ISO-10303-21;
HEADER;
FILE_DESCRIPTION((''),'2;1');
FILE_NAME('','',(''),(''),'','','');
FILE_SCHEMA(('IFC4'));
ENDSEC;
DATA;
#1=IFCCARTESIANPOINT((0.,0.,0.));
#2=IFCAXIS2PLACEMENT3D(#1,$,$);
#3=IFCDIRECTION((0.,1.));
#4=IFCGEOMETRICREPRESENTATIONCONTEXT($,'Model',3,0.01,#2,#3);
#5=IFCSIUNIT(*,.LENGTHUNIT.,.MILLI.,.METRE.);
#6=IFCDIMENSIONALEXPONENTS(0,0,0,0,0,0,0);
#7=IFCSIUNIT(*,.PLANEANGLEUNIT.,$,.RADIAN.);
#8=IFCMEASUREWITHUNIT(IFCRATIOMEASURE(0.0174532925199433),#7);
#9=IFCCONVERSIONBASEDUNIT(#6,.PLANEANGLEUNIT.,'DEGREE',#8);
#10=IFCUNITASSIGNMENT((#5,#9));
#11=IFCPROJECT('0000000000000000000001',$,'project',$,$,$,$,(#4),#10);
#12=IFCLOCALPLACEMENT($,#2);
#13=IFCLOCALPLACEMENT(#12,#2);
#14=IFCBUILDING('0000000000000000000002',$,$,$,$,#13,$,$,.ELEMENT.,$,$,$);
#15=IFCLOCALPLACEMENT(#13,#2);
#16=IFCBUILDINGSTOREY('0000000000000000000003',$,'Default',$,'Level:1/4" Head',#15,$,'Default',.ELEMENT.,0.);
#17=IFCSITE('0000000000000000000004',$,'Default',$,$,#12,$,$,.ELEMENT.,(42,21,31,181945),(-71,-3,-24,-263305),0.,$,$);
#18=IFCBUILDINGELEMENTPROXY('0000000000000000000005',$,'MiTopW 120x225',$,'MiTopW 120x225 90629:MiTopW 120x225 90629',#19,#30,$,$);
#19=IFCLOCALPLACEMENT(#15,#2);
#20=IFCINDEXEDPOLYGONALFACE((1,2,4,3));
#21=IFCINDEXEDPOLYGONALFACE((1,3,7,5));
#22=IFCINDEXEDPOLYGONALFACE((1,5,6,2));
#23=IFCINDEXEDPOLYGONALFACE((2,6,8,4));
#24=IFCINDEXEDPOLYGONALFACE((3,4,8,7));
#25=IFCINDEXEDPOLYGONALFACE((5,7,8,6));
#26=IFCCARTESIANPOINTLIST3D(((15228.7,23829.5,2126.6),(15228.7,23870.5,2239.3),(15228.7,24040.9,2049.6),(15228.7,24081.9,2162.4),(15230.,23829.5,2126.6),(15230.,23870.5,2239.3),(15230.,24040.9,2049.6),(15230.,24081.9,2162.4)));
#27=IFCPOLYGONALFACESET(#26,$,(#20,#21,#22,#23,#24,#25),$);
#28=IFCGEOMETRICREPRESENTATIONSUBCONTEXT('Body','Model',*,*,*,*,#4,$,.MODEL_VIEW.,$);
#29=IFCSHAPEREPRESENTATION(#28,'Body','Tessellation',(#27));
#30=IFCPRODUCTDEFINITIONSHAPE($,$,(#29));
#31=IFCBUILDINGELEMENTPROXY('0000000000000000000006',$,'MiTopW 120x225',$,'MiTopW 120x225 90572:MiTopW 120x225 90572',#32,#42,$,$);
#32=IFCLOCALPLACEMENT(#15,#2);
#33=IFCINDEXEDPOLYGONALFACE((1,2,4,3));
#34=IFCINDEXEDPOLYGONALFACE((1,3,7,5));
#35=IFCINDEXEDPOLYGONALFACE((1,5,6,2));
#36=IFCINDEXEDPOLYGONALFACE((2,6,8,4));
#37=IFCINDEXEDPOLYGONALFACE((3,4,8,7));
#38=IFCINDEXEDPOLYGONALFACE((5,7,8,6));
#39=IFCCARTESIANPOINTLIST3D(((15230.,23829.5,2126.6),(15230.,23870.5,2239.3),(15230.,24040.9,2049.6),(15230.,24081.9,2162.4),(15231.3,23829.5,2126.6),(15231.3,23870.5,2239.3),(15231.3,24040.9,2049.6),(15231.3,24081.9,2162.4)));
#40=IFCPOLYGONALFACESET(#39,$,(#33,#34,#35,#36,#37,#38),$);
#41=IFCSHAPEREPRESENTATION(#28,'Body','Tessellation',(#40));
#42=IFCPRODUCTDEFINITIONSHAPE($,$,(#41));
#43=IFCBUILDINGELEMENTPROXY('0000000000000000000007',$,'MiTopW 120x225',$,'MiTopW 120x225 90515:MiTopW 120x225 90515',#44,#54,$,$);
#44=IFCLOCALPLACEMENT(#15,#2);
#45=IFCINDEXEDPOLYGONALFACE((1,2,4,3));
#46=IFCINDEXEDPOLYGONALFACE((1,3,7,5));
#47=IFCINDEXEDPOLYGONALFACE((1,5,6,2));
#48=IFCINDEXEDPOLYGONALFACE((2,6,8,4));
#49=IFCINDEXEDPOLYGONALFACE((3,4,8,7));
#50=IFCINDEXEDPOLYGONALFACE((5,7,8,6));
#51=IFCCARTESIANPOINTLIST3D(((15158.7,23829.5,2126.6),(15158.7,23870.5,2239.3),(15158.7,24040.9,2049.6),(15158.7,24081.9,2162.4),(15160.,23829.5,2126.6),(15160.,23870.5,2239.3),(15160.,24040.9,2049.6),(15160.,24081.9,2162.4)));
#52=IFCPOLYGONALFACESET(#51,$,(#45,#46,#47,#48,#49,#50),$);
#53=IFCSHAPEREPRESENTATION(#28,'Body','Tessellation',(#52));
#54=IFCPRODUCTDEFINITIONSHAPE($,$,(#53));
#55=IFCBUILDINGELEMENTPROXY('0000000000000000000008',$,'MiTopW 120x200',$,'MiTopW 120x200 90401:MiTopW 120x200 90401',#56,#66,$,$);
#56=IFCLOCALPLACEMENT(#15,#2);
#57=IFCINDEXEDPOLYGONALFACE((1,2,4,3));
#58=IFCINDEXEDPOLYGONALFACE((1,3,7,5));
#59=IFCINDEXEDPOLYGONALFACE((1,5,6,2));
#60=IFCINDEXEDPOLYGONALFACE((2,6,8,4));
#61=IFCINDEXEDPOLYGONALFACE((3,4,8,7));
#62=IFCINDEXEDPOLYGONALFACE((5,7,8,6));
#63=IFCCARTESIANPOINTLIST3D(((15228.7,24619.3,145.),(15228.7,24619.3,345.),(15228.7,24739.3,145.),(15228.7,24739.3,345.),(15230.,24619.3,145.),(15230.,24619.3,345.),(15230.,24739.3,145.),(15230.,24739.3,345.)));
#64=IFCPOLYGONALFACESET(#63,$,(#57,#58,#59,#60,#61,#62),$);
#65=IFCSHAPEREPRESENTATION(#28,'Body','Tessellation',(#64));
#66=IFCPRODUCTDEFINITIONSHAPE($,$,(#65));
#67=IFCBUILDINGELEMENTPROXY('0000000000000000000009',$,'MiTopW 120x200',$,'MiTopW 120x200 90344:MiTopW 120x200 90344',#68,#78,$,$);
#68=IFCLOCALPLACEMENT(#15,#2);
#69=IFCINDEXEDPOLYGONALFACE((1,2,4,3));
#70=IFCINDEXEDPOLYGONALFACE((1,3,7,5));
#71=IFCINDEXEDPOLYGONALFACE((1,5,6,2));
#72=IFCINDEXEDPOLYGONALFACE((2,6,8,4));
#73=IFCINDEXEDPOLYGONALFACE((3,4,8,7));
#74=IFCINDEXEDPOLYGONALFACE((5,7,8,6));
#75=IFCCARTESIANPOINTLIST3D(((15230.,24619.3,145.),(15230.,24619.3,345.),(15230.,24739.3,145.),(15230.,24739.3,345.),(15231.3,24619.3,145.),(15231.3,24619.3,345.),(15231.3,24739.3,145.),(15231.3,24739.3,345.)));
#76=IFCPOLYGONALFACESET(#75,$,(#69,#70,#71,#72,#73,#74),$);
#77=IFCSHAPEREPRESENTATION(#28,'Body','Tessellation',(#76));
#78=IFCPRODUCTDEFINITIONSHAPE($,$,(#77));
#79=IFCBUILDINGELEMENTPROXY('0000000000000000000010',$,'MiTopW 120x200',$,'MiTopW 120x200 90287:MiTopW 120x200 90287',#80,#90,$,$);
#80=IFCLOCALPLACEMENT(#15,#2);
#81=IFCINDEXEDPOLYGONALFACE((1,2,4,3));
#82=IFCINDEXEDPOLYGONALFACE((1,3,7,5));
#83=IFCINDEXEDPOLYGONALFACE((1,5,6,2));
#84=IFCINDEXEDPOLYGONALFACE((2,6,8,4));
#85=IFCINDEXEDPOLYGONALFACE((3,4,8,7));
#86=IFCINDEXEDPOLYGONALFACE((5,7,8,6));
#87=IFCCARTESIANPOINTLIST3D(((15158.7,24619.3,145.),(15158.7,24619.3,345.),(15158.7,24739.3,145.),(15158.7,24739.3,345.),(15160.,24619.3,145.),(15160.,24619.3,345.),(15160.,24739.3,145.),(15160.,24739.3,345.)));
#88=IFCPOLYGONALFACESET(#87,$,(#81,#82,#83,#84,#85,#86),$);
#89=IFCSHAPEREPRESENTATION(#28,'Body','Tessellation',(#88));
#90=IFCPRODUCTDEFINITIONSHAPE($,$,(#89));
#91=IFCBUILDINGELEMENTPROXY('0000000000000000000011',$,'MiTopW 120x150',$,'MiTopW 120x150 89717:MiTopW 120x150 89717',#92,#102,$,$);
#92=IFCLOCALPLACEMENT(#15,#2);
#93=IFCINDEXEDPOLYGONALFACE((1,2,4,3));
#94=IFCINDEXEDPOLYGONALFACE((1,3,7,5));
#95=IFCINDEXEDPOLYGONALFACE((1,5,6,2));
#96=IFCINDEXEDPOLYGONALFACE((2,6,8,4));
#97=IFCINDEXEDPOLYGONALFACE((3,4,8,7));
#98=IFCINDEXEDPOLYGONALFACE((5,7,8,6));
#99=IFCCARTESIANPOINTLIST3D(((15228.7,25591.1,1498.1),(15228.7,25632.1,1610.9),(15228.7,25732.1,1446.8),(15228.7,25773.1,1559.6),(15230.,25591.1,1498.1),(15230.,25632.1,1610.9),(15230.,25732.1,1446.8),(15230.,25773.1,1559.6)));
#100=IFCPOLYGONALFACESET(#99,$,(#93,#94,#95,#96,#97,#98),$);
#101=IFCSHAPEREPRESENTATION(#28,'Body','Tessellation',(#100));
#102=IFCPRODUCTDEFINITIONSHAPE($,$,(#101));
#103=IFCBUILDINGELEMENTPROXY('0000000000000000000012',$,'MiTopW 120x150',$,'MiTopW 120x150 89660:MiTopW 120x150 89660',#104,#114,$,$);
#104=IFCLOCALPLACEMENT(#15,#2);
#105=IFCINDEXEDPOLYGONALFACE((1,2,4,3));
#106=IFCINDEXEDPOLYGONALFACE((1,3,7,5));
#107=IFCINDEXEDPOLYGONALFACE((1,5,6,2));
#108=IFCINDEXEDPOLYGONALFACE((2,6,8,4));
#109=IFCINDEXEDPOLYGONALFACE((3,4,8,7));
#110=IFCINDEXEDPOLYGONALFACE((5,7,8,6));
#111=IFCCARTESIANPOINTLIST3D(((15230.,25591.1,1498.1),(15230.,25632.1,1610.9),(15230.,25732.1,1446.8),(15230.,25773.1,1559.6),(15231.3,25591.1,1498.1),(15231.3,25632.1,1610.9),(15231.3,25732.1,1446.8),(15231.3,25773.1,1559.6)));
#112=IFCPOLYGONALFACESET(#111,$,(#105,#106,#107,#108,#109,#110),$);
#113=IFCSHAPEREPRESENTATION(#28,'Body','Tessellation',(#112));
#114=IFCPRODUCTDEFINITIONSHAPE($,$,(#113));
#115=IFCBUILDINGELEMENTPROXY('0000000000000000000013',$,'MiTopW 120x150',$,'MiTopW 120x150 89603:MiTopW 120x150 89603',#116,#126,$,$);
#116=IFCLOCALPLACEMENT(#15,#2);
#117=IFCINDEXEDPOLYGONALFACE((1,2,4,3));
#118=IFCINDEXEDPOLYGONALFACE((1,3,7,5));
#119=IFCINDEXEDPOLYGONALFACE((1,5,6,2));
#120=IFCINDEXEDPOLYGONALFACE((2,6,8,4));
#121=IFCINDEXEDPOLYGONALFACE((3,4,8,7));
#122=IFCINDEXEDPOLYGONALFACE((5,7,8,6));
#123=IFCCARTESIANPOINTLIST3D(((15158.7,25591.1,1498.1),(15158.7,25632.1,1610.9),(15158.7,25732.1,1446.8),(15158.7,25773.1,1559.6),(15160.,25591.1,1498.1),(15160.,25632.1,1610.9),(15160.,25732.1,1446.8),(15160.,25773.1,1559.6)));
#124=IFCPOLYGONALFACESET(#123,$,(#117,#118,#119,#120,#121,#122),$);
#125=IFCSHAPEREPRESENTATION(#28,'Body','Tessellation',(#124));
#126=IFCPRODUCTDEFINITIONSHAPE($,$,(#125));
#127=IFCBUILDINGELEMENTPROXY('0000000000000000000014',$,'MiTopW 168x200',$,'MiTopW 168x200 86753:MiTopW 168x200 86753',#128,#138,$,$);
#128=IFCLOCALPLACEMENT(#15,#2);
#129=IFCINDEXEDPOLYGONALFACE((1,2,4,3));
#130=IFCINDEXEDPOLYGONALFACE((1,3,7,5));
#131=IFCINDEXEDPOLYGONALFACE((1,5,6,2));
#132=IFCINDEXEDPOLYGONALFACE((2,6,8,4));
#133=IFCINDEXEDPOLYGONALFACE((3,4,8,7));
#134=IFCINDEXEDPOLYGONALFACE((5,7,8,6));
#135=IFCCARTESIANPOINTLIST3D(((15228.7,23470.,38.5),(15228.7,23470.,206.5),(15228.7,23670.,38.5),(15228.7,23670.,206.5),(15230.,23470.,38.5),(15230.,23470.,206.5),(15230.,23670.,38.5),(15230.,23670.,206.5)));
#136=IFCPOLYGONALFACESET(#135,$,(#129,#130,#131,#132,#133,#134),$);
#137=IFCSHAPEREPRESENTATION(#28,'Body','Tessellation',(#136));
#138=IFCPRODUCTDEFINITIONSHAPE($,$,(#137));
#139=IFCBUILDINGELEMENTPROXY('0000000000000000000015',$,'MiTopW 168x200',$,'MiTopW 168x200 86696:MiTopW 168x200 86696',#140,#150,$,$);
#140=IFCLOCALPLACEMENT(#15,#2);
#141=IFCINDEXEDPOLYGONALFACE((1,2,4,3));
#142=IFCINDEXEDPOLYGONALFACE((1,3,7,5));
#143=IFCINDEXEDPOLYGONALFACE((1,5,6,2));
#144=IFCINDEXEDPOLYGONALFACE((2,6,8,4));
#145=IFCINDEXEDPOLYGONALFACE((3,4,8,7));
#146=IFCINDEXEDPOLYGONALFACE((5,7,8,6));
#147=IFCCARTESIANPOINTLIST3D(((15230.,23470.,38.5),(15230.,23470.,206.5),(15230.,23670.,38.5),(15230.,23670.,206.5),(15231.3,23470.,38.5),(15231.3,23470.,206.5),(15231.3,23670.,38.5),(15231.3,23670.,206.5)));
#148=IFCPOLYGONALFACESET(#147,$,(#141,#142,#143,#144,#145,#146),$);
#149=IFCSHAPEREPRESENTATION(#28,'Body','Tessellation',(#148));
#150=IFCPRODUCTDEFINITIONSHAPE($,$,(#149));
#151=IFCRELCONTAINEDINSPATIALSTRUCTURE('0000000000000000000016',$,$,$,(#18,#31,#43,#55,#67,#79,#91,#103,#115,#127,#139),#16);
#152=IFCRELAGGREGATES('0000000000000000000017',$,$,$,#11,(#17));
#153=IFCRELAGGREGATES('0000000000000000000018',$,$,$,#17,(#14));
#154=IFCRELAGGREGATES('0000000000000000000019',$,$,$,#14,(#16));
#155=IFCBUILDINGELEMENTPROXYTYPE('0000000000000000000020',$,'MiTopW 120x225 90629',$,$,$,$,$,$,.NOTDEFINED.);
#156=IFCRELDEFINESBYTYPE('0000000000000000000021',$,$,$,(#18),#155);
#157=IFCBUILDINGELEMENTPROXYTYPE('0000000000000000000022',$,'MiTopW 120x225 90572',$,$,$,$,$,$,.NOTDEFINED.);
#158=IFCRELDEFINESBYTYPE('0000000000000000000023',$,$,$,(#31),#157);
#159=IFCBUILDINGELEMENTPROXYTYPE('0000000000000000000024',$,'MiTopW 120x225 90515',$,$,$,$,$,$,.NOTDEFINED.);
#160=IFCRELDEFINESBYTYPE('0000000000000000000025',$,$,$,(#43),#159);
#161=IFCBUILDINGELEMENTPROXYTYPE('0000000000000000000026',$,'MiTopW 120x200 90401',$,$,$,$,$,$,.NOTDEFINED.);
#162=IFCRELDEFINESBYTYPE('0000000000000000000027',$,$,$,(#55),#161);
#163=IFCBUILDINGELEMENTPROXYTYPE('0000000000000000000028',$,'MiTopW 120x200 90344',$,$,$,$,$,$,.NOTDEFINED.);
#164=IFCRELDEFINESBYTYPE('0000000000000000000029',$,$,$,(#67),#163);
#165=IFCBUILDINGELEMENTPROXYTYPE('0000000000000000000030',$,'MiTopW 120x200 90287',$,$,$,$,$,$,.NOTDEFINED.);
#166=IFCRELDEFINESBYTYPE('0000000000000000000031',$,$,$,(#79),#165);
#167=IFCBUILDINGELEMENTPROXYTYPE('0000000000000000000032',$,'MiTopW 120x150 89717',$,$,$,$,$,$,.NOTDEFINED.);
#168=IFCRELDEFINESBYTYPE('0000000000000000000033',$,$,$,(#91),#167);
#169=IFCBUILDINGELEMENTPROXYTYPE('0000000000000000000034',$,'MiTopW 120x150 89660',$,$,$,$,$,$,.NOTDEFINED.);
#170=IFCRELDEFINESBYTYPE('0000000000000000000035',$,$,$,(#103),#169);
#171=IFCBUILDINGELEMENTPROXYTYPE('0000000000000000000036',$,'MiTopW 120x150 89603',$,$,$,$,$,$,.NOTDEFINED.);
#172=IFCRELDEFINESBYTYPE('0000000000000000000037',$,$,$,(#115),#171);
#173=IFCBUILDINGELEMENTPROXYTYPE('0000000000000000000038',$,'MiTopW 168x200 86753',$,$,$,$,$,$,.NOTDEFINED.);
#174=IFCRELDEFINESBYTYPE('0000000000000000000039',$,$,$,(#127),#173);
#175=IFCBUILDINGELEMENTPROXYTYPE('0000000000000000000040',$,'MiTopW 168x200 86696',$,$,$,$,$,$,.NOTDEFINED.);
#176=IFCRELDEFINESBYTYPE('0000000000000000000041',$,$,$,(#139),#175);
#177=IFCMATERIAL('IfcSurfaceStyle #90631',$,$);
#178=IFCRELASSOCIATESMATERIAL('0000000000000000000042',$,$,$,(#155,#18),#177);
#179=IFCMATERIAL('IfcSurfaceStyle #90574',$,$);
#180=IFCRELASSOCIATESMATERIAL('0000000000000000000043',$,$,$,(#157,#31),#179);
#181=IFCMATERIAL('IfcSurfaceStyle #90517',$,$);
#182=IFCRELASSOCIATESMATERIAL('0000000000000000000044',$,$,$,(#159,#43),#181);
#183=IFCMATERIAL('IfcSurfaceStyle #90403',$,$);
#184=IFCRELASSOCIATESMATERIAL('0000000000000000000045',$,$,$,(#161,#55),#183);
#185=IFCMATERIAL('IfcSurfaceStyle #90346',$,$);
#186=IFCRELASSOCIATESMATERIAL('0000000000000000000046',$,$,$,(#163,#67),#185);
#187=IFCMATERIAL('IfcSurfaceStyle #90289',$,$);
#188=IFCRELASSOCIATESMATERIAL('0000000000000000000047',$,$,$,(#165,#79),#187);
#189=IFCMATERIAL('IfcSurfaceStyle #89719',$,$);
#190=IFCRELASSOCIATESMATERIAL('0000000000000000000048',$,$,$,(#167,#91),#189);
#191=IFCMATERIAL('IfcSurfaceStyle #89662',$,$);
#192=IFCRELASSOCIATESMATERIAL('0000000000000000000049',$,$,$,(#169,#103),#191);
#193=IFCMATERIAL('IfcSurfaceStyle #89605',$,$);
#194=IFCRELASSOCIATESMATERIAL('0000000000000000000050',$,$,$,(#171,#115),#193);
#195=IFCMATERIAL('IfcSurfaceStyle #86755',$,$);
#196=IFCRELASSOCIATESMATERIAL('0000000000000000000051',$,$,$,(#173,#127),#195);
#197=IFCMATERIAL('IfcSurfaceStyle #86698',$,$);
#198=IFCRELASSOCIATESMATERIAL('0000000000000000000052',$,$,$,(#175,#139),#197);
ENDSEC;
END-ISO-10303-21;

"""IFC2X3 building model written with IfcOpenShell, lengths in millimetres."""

from ifc_helpers import new_model, entity, si_unit, converted_unit, direction, frame, origin, origin_2d_with_axis, place, context, subcontext, project, spatial, polyline, rectangle, outline, extrude, source, transform, mapped, material, type_object, type_shapes, element, save


model = new_model("IFC2X3")

# Units and contexts
model_context = context("Model", 3, precision=0.01, world=origin(), true_north=direction((0.0, 1.0)))
body_context = subcontext(model_context, "Body", "Model", "MODEL_VIEW")
ifc_project = project(units=[si_unit("LENGTHUNIT", "METRE", prefix="MILLI"), converted_unit("PLANEANGLEUNIT", "DEGREE", entity("IfcRatioMeasure", 0.0174532925199433), si_unit("PLANEANGLEUNIT", "RADIAN"), dimensions=[0, 0, 0, 0, 0, 0, 0])], contexts=[model_context])

# Site, building, storey
site_placement = place(None, origin())
site = spatial("IfcSite", under=ifc_project, at=site_placement, Name="Default", CompositionType="ELEMENT", RefLatitude=(42, 21, 31, 181945), RefLongitude=(-71, -3, -24, -263305), RefElevation=0.0)
building_placement = place(site_placement, origin())
building = spatial("IfcBuilding", under=site, at=building_placement, CompositionType="ELEMENT")
storey_placement = place(building_placement, origin())
storey = spatial("IfcBuildingStorey", under=building, at=storey_placement, Name="Default", ObjectType="Level:1/4\" Head", LongName="Default", CompositionType="ELEMENT", Elevation=0.0)

# Building element proxies
ifc_material_1 = material(Name="IfcSurfaceStyle #90631")
building_element_proxy_type_1 = type_object("IfcBuildingElementProxyType", Name="MiTopW 120x225 90629", PredefinedType="NOTDEFINED", material=ifc_material_1)
shared_shape_1 = source(origin(), body_context, "Body", "SweptSolid", [
    extrude(outline(polyline([(-112.5, -60.0), (112.5, -60.0), (112.5, 60.0), (-112.5, 60.0), (-112.5, -60.0)])), frame((112.5, 60.0, 0.0), z_axis=(0.0, 0.0, 1.0), x_axis=(-1.0, 0.0, 0.0)), (0.0, 0.0, 1.0), 1.3),
])
type_shapes(building_element_proxy_type_1, [shared_shape_1])
proxy_1_placement = place(building_placement, frame((15230.0, 24040.9, 2049.6), z_axis=(-1.0, 0.0, 0.0), x_axis=(0.0, -0.939693, 0.34202)))
element("IfcBuildingElementProxy", 1, at=proxy_1_placement, inside=storey, type_object=building_element_proxy_type_1, material=ifc_material_1, Name="MiTopW 120x225", ObjectType="MiTopW 120x225 90629:MiTopW 120x225 90629", context=body_context, shape_type="MappedRepresentation", body=[
    mapped(shared_shape_1, transform((0.0, 0.0, 0.0), scale=1.0)),
])
ifc_material_2 = material(Name="IfcSurfaceStyle #90574")
building_element_proxy_type_2 = type_object("IfcBuildingElementProxyType", Name="MiTopW 120x225 90572", PredefinedType="NOTDEFINED", material=ifc_material_2)
shared_shape_2 = source(origin(), body_context, "Body", "SweptSolid", [
    extrude(outline(polyline([(-112.5, -60.0), (112.5, -60.0), (112.5, 60.0), (-112.5, 60.0), (-112.5, -60.0)])), frame((112.5, 60.0, 0.0), z_axis=(0.0, 0.0, 1.0), x_axis=(-1.0, 0.0, 0.0)), (0.0, 0.0, 1.0), 1.3),
])
type_shapes(building_element_proxy_type_2, [shared_shape_2])
proxy_2_placement = place(building_placement, frame((15231.3, 24040.9, 2049.6), z_axis=(-1.0, 0.0, 0.0), x_axis=(0.0, -0.939693, 0.34202)))
element("IfcBuildingElementProxy", 2, at=proxy_2_placement, inside=storey, type_object=building_element_proxy_type_2, material=ifc_material_2, Name="MiTopW 120x225", ObjectType="MiTopW 120x225 90572:MiTopW 120x225 90572", context=body_context, shape_type="MappedRepresentation", body=[
    mapped(shared_shape_2, transform((0.0, 0.0, 0.0), scale=1.0)),
])
ifc_material_3 = material(Name="IfcSurfaceStyle #90517")
building_element_proxy_type_3 = type_object("IfcBuildingElementProxyType", Name="MiTopW 120x225 90515", PredefinedType="NOTDEFINED", material=ifc_material_3)
shared_shape_3 = source(origin(), body_context, "Body", "SweptSolid", [
    extrude(outline(polyline([(-112.5, -60.0), (112.5, -60.0), (112.5, 60.0), (-112.5, 60.0), (-112.5, -60.0)])), frame((112.5, 60.0, 0.0), z_axis=(0.0, 0.0, 1.0), x_axis=(-1.0, 0.0, 0.0)), (0.0, 0.0, 1.0), 1.3),
])
type_shapes(building_element_proxy_type_3, [shared_shape_3])
proxy_3_placement = place(building_placement, frame((15160.0, 24040.9, 2049.6), z_axis=(-1.0, 0.0, 0.0), x_axis=(0.0, -0.939693, 0.34202)))
element("IfcBuildingElementProxy", 3, at=proxy_3_placement, inside=storey, type_object=building_element_proxy_type_3, material=ifc_material_3, Name="MiTopW 120x225", ObjectType="MiTopW 120x225 90515:MiTopW 120x225 90515", context=body_context, shape_type="MappedRepresentation", body=[
    mapped(shared_shape_3, transform((0.0, 0.0, 0.0), scale=1.0)),
])
ifc_material_4 = material(Name="IfcSurfaceStyle #90403")
building_element_proxy_type_4 = type_object("IfcBuildingElementProxyType", Name="MiTopW 120x200 90401", PredefinedType="NOTDEFINED", material=ifc_material_4)
shared_shape_4 = source(origin(), body_context, "Body", "SweptSolid", [
    extrude(rectangle(XDim=200.0, YDim=120.0, at=origin_2d_with_axis()), frame((100.0, 60.0, 0.0), z_axis=(0.0, 0.0, 1.0), x_axis=(-1.0, 0.0, 0.0)), (0.0, 0.0, 1.0), 1.3),
])
type_shapes(building_element_proxy_type_4, [shared_shape_4])
proxy_4_placement = place(building_placement, frame((15230.0, 24619.3, 145.0), z_axis=(-1.0, 0.0, 0.0), x_axis=(0.0, 0.0, 1.0)))
element("IfcBuildingElementProxy", 4, at=proxy_4_placement, inside=storey, type_object=building_element_proxy_type_4, material=ifc_material_4, Name="MiTopW 120x200", ObjectType="MiTopW 120x200 90401:MiTopW 120x200 90401", context=body_context, shape_type="MappedRepresentation", body=[
    mapped(shared_shape_4, transform((0.0, 0.0, 0.0), scale=1.0)),
])
ifc_material_5 = material(Name="IfcSurfaceStyle #90346")
building_element_proxy_type_5 = type_object("IfcBuildingElementProxyType", Name="MiTopW 120x200 90344", PredefinedType="NOTDEFINED", material=ifc_material_5)
shared_shape_5 = source(origin(), body_context, "Body", "SweptSolid", [
    extrude(rectangle(XDim=200.0, YDim=120.0, at=origin_2d_with_axis()), frame((100.0, 60.0, 0.0), z_axis=(0.0, 0.0, 1.0), x_axis=(-1.0, 0.0, 0.0)), (0.0, 0.0, 1.0), 1.3),
])
type_shapes(building_element_proxy_type_5, [shared_shape_5])
proxy_5_placement = place(building_placement, frame((15231.3, 24619.3, 145.0), z_axis=(-1.0, 0.0, 0.0), x_axis=(0.0, 0.0, 1.0)))
element("IfcBuildingElementProxy", 5, at=proxy_5_placement, inside=storey, type_object=building_element_proxy_type_5, material=ifc_material_5, Name="MiTopW 120x200", ObjectType="MiTopW 120x200 90344:MiTopW 120x200 90344", context=body_context, shape_type="MappedRepresentation", body=[
    mapped(shared_shape_5, transform((0.0, 0.0, 0.0), scale=1.0)),
])
ifc_material_6 = material(Name="IfcSurfaceStyle #90289")
building_element_proxy_type_6 = type_object("IfcBuildingElementProxyType", Name="MiTopW 120x200 90287", PredefinedType="NOTDEFINED", material=ifc_material_6)
shared_shape_6 = source(origin(), body_context, "Body", "SweptSolid", [
    extrude(rectangle(XDim=200.0, YDim=120.0, at=origin_2d_with_axis()), frame((100.0, 60.0, 0.0), z_axis=(0.0, 0.0, 1.0), x_axis=(-1.0, 0.0, 0.0)), (0.0, 0.0, 1.0), 1.3),
])
type_shapes(building_element_proxy_type_6, [shared_shape_6])
proxy_6_placement = place(building_placement, frame((15160.0, 24619.3, 145.0), z_axis=(-1.0, 0.0, 0.0), x_axis=(0.0, 0.0, 1.0)))
element("IfcBuildingElementProxy", 6, at=proxy_6_placement, inside=storey, type_object=building_element_proxy_type_6, material=ifc_material_6, Name="MiTopW 120x200", ObjectType="MiTopW 120x200 90287:MiTopW 120x200 90287", context=body_context, shape_type="MappedRepresentation", body=[
    mapped(shared_shape_6, transform((0.0, 0.0, 0.0), scale=1.0)),
])
ifc_material_7 = material(Name="IfcSurfaceStyle #89719")
building_element_proxy_type_7 = type_object("IfcBuildingElementProxyType", Name="MiTopW 120x150 89717", PredefinedType="NOTDEFINED", material=ifc_material_7)
shared_shape_7 = source(origin(), body_context, "Body", "SweptSolid", [
    extrude(outline(polyline([(-75.0, -60.0), (75.0, -60.0), (75.0, 60.0), (-75.0, 60.0), (-75.0, -60.0)])), frame((75.0, 60.0, 0.0), z_axis=(0.0, 0.0, 1.0), x_axis=(-1.0, 0.0, 0.0)), (0.0, 0.0, 1.0), 1.3),
])
type_shapes(building_element_proxy_type_7, [shared_shape_7])
proxy_7_placement = place(building_placement, frame((15230.0, 25732.1, 1446.8), z_axis=(-1.0, 0.0, 0.0), x_axis=(0.0, -0.939693, 0.34202)))
element("IfcBuildingElementProxy", 7, at=proxy_7_placement, inside=storey, type_object=building_element_proxy_type_7, material=ifc_material_7, Name="MiTopW 120x150", ObjectType="MiTopW 120x150 89717:MiTopW 120x150 89717", context=body_context, shape_type="MappedRepresentation", body=[
    mapped(shared_shape_7, transform((0.0, 0.0, 0.0), scale=1.0)),
])
ifc_material_8 = material(Name="IfcSurfaceStyle #89662")
building_element_proxy_type_8 = type_object("IfcBuildingElementProxyType", Name="MiTopW 120x150 89660", PredefinedType="NOTDEFINED", material=ifc_material_8)
shared_shape_8 = source(origin(), body_context, "Body", "SweptSolid", [
    extrude(outline(polyline([(-75.0, -60.0), (75.0, -60.0), (75.0, 60.0), (-75.0, 60.0), (-75.0, -60.0)])), frame((75.0, 60.0, 0.0), z_axis=(0.0, 0.0, 1.0), x_axis=(-1.0, 0.0, 0.0)), (0.0, 0.0, 1.0), 1.3),
])
type_shapes(building_element_proxy_type_8, [shared_shape_8])
proxy_8_placement = place(building_placement, frame((15231.3, 25732.1, 1446.8), z_axis=(-1.0, 0.0, 0.0), x_axis=(0.0, -0.939693, 0.34202)))
element("IfcBuildingElementProxy", 8, at=proxy_8_placement, inside=storey, type_object=building_element_proxy_type_8, material=ifc_material_8, Name="MiTopW 120x150", ObjectType="MiTopW 120x150 89660:MiTopW 120x150 89660", context=body_context, shape_type="MappedRepresentation", body=[
    mapped(shared_shape_8, transform((0.0, 0.0, 0.0), scale=1.0)),
])
ifc_material_9 = material(Name="IfcSurfaceStyle #89605")
building_element_proxy_type_9 = type_object("IfcBuildingElementProxyType", Name="MiTopW 120x150 89603", PredefinedType="NOTDEFINED", material=ifc_material_9)
shared_shape_9 = source(origin(), body_context, "Body", "SweptSolid", [
    extrude(outline(polyline([(-75.0, -60.0), (75.0, -60.0), (75.0, 60.0), (-75.0, 60.0), (-75.0, -60.0)])), frame((75.0, 60.0, 0.0), z_axis=(0.0, 0.0, 1.0), x_axis=(-1.0, 0.0, 0.0)), (0.0, 0.0, 1.0), 1.3),
])
type_shapes(building_element_proxy_type_9, [shared_shape_9])
proxy_9_placement = place(building_placement, frame((15160.0, 25732.1, 1446.8), z_axis=(-1.0, 0.0, 0.0), x_axis=(0.0, -0.939693, 0.34202)))
element("IfcBuildingElementProxy", 9, at=proxy_9_placement, inside=storey, type_object=building_element_proxy_type_9, material=ifc_material_9, Name="MiTopW 120x150", ObjectType="MiTopW 120x150 89603:MiTopW 120x150 89603", context=body_context, shape_type="MappedRepresentation", body=[
    mapped(shared_shape_9, transform((0.0, 0.0, 0.0), scale=1.0)),
])
ifc_material_10 = material(Name="IfcSurfaceStyle #86755")
building_element_proxy_type_10 = type_object("IfcBuildingElementProxyType", Name="MiTopW 168x200 86753", PredefinedType="NOTDEFINED", material=ifc_material_10)
shared_shape_10 = source(origin(), body_context, "Body", "SweptSolid", [
    extrude(rectangle(XDim=200.0, YDim=168.0, at=origin_2d_with_axis()), frame((100.0, 84.0, 0.0), z_axis=(0.0, 0.0, 1.0), x_axis=(-1.0, 0.0, 0.0)), (0.0, 0.0, 1.0), 1.3),
])
type_shapes(building_element_proxy_type_10, [shared_shape_10])
proxy_10_placement = place(building_placement, frame((15230.0, 23470.0, 206.5), z_axis=(-1.0, 0.0, 0.0), x_axis=(0.0, 1.0, 0.0)))
element("IfcBuildingElementProxy", 10, at=proxy_10_placement, inside=storey, type_object=building_element_proxy_type_10, material=ifc_material_10, Name="MiTopW 168x200", ObjectType="MiTopW 168x200 86753:MiTopW 168x200 86753", context=body_context, shape_type="MappedRepresentation", body=[
    mapped(shared_shape_10, transform((0.0, 0.0, 0.0), scale=1.0)),
])
ifc_material_11 = material(Name="IfcSurfaceStyle #86698")
building_element_proxy_type_11 = type_object("IfcBuildingElementProxyType", Name="MiTopW 168x200 86696", PredefinedType="NOTDEFINED", material=ifc_material_11)
shared_shape_11 = source(origin(), body_context, "Body", "SweptSolid", [
    extrude(rectangle(XDim=200.0, YDim=168.0, at=origin_2d_with_axis()), frame((100.0, 84.0, 0.0), z_axis=(0.0, 0.0, 1.0), x_axis=(-1.0, 0.0, 0.0)), (0.0, 0.0, 1.0), 1.3),
])
type_shapes(building_element_proxy_type_11, [shared_shape_11])
proxy_11_placement = place(building_placement, frame((15231.3, 23470.0, 206.5), z_axis=(-1.0, 0.0, 0.0), x_axis=(0.0, 1.0, 0.0)))
element("IfcBuildingElementProxy", 11, at=proxy_11_placement, inside=storey, type_object=building_element_proxy_type_11, material=ifc_material_11, Name="MiTopW 168x200", ObjectType="MiTopW 168x200 86696:MiTopW 168x200 86696", context=body_context, shape_type="MappedRepresentation", body=[
    mapped(shared_shape_11, transform((0.0, 0.0, 0.0), scale=1.0)),
])

save(model, "model.ifc")
